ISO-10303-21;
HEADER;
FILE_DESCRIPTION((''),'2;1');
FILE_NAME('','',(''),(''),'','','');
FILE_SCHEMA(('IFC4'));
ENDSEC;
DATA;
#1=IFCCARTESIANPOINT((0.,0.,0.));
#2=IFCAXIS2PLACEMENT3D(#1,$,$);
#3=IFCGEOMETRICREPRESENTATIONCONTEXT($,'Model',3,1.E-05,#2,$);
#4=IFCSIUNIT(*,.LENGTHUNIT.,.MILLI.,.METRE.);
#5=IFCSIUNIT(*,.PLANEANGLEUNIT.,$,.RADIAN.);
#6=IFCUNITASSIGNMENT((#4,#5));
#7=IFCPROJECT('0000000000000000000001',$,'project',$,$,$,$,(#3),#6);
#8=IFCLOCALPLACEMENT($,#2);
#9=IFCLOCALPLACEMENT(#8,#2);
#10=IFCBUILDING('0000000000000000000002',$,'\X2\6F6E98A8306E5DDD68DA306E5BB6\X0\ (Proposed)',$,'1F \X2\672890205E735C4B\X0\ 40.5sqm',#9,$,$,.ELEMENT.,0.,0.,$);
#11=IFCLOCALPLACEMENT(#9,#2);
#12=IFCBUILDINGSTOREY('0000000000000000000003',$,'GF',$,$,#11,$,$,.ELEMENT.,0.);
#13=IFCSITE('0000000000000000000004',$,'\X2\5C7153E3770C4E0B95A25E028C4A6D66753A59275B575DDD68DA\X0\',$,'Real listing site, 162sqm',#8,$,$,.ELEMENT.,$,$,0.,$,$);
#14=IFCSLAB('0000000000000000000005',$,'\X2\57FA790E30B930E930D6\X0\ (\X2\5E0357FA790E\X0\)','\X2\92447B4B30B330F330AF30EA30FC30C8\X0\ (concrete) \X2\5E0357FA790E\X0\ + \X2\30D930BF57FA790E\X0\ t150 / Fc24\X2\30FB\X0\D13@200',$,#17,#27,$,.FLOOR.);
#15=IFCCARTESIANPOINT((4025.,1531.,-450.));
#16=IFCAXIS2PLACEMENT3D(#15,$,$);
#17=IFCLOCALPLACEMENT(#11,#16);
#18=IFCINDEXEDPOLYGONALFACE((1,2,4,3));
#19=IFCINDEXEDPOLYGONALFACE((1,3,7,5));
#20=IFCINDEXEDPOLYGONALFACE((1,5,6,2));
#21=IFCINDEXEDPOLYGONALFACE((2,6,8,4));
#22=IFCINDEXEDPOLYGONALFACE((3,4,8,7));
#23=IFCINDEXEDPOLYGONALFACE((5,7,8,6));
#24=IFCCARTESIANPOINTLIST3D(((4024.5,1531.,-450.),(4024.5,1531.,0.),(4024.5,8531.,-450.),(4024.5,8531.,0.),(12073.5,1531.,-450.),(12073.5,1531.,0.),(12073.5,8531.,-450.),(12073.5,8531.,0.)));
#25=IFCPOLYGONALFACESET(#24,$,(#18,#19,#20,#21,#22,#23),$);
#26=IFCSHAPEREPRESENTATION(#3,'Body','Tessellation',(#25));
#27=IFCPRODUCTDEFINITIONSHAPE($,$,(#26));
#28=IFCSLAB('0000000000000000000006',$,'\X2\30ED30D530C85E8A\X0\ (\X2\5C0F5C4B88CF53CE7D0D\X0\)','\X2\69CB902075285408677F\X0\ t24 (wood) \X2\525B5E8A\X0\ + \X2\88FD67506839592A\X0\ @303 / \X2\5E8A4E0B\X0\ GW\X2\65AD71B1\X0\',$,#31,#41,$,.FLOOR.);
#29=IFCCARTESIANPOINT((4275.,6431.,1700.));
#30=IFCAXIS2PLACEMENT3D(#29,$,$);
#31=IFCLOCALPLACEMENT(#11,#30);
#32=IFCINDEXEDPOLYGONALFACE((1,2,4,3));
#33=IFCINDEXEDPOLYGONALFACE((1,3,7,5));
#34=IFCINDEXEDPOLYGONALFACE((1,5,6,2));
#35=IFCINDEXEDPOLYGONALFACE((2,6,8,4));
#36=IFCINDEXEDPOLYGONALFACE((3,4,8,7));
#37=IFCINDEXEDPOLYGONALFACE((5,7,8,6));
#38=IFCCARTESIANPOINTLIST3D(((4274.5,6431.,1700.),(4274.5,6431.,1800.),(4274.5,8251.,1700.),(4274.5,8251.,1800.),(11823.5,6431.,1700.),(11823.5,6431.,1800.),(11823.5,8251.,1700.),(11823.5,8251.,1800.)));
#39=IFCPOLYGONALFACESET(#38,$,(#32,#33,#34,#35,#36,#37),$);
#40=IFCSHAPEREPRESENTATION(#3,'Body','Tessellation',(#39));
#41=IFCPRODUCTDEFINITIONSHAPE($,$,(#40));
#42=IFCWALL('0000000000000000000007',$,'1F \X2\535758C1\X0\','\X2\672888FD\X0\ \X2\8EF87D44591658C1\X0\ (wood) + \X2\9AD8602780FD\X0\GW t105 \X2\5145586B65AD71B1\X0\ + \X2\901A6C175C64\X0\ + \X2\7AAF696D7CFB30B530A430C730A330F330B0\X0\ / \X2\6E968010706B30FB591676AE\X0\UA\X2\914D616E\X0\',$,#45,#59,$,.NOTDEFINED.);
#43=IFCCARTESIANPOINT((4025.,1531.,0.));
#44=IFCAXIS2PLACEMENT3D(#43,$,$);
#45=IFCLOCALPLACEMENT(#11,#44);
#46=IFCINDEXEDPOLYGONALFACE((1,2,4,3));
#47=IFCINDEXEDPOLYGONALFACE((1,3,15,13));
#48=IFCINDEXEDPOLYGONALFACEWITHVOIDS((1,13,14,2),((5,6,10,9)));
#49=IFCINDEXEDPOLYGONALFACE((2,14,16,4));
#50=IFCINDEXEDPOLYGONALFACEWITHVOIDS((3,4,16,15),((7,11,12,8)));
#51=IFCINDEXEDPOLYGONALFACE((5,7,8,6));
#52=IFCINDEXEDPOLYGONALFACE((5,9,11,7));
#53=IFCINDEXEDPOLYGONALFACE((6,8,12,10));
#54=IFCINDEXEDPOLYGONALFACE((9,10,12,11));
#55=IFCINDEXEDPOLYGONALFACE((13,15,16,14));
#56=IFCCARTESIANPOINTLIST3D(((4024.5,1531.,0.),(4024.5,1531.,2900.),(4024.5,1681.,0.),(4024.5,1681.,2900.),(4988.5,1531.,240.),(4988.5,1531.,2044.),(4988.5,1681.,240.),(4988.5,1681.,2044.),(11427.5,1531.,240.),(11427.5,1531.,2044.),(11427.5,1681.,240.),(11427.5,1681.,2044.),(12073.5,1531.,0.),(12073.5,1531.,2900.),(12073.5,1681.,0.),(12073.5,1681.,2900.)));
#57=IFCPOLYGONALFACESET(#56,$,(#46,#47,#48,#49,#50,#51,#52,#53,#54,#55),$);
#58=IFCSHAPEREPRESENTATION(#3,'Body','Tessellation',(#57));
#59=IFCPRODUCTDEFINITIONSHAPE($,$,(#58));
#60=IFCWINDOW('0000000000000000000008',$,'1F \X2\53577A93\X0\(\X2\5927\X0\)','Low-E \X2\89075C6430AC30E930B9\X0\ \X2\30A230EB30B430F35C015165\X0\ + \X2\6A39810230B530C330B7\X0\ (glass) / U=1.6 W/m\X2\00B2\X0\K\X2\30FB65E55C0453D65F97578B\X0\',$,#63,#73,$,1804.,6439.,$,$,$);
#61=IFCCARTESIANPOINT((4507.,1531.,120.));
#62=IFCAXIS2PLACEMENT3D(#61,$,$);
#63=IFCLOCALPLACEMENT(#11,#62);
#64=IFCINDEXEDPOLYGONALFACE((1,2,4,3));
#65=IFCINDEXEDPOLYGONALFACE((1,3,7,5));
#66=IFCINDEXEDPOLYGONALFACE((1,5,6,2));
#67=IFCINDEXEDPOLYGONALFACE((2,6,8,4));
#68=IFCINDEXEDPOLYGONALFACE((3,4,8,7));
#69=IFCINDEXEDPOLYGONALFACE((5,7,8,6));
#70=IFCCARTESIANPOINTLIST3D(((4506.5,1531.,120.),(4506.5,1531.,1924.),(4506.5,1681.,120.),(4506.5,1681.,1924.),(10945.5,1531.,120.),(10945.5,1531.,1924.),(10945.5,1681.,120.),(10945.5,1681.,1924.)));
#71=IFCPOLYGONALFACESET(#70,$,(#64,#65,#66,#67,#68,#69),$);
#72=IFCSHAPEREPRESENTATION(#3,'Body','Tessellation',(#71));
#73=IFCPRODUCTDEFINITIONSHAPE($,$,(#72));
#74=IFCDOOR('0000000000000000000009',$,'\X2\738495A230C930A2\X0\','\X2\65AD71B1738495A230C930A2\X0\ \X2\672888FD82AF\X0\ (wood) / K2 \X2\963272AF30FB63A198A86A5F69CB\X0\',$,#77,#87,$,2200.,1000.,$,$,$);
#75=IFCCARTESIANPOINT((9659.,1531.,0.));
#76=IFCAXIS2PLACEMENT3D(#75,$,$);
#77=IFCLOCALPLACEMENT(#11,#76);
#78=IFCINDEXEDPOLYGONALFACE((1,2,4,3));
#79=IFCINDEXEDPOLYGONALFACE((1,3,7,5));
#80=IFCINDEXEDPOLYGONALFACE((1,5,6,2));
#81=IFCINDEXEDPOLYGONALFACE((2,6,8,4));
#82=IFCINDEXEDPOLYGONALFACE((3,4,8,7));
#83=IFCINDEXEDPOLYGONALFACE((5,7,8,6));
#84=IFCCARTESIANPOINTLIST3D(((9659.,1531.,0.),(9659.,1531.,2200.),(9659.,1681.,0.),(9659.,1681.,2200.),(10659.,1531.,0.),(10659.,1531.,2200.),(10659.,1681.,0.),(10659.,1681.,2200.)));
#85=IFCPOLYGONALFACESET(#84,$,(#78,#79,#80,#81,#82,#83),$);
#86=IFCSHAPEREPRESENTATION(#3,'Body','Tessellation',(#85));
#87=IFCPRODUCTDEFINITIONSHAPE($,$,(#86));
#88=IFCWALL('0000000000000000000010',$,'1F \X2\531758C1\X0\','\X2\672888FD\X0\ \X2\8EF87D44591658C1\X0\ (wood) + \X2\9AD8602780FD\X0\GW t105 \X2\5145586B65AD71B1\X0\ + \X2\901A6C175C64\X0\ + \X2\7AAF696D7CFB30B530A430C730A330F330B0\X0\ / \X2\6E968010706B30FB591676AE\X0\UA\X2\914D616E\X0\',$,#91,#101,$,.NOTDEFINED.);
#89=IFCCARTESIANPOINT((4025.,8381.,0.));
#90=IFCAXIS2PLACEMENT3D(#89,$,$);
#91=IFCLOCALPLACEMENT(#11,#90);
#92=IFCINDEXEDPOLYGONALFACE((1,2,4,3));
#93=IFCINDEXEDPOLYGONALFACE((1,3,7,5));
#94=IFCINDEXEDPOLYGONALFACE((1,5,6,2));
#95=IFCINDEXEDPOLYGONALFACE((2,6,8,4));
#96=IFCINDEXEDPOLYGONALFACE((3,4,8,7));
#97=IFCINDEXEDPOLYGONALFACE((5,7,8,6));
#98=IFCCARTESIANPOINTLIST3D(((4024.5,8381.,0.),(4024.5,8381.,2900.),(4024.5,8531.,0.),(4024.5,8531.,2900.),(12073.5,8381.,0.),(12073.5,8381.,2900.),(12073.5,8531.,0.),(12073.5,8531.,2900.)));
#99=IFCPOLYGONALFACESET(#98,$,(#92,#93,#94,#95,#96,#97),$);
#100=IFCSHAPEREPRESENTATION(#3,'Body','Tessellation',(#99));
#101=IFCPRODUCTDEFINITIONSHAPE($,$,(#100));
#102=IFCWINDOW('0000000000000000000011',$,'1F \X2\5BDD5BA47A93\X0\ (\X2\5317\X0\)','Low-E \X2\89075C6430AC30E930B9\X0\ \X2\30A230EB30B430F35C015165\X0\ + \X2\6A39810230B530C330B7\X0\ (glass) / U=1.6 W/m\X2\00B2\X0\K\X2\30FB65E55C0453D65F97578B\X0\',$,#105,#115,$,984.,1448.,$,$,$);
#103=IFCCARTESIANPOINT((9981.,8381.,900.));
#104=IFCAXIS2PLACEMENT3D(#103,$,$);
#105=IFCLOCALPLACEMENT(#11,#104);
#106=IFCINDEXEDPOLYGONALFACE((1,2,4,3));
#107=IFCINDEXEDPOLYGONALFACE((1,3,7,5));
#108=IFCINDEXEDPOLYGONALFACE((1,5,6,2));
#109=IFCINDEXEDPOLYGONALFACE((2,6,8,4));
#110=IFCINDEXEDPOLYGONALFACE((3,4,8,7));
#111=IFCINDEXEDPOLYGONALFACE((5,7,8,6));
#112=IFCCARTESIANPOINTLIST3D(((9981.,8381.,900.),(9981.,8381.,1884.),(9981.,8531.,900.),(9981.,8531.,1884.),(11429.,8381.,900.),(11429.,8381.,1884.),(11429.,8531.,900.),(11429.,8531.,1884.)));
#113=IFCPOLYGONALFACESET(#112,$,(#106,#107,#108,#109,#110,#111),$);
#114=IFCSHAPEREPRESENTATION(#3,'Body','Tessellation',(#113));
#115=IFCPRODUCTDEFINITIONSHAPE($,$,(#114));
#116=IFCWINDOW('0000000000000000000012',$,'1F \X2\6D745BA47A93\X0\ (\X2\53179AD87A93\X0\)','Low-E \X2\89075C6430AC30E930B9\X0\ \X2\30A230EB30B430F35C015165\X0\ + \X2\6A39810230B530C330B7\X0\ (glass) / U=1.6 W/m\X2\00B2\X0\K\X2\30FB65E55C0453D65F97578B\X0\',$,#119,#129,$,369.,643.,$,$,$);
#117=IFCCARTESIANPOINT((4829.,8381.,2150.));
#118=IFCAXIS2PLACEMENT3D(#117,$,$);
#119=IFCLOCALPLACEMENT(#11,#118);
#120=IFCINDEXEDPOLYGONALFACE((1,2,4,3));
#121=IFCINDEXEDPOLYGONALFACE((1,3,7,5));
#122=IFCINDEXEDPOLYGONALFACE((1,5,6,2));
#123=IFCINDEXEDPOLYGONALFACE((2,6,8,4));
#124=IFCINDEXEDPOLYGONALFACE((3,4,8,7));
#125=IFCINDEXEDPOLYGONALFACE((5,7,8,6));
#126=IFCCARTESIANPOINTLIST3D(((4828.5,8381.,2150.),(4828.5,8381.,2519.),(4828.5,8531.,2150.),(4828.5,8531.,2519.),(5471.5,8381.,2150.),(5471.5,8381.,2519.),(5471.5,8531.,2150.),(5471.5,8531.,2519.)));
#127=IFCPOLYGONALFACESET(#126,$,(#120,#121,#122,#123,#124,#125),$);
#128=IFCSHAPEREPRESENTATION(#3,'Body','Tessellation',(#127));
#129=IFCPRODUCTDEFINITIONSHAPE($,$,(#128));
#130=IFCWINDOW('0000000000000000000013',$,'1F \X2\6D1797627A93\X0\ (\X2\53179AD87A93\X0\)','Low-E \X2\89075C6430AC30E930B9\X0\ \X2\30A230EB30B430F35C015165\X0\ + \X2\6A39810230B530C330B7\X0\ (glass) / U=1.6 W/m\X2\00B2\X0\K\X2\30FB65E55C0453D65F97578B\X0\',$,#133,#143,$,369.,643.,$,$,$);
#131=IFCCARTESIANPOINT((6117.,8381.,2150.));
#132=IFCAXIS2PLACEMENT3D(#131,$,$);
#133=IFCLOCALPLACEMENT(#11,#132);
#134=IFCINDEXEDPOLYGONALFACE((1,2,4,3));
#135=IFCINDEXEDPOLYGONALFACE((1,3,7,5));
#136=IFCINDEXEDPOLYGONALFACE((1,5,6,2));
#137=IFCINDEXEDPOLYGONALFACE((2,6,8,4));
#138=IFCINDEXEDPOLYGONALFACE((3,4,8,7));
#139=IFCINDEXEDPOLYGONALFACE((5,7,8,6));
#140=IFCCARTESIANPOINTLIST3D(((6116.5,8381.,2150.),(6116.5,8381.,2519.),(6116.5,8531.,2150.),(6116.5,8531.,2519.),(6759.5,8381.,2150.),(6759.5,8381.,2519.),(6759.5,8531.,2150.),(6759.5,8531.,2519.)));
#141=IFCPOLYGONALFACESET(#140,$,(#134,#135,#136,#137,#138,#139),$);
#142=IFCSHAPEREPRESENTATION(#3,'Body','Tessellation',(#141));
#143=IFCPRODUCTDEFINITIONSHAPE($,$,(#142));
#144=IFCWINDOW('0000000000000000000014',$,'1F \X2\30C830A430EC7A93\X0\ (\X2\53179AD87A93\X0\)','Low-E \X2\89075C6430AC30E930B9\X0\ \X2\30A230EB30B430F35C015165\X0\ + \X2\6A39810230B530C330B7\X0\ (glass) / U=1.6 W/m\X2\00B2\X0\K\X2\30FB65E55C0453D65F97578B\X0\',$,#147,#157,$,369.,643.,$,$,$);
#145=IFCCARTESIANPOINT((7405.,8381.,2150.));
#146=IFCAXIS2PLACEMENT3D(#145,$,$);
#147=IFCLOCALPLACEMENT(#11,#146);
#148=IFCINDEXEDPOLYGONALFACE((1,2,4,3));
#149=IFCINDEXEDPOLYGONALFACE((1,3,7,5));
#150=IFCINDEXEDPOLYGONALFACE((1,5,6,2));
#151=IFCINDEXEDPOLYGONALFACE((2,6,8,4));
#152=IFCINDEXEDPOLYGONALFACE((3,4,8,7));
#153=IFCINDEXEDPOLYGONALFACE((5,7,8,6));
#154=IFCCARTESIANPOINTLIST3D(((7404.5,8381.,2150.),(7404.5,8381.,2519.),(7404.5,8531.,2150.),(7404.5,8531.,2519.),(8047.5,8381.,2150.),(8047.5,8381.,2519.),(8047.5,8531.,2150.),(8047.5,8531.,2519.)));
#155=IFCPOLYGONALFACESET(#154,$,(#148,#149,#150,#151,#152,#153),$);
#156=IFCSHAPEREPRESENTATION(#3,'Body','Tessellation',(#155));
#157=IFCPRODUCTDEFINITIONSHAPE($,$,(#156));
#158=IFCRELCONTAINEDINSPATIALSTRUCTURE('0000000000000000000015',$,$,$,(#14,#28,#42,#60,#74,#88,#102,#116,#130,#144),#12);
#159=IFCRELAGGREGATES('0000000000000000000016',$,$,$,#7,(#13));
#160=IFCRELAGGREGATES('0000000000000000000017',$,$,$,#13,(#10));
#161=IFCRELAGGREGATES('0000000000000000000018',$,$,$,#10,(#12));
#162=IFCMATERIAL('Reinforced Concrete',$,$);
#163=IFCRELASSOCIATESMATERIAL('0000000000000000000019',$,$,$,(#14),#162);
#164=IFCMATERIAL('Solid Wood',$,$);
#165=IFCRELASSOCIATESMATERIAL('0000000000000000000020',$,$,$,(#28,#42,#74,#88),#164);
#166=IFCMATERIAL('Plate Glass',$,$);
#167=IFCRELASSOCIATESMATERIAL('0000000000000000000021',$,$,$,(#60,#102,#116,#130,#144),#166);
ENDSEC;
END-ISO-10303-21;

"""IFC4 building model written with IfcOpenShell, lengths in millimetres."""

from ifc_helpers import new_model, si_unit, frame, frame_2d, origin, place, context, project, spatial, rectangle, extrude, material, element, fill, save


model = new_model("IFC4")

# Units and contexts
model_context = context("Model", 3, precision=1e-05, world=origin())
ifc_project = project(units=[si_unit("LENGTHUNIT", "METRE", prefix="MILLI"), si_unit("PLANEANGLEUNIT", "RADIAN")], contexts=[model_context])

# Site, building, storey
site_placement = place(None, origin())
site = spatial("IfcSite", under=ifc_project, at=site_placement, Name="山口県下関市豊浦町大字川棚", ObjectType="Real listing site, 162sqm", CompositionType="ELEMENT", RefElevation=0.0)
building_placement = place(site_placement, origin())
building = spatial("IfcBuilding", under=site, at=building_placement, Name="潮風の川棚の家 (Proposed)", ObjectType="1F 木造平屋 40.5sqm", CompositionType="ELEMENT", ElevationOfRefHeight=0.0, ElevationOfTerrain=0.0)
storey_placement = place(building_placement, origin())
storey = spatial("IfcBuildingStorey", under=building, at=storey_placement, Name="GF", CompositionType="ELEMENT", Elevation=0.0)

# Slabs
ifc_material_1 = material(Name="Reinforced Concrete")
slab_1_placement = place(storey_placement, frame((4025.0, 1531.0, -450.0)))
element("IfcSlab", 1, at=slab_1_placement, inside=storey, material=ifc_material_1, Name="基礎スラブ (布基礎)", Description="鉄筋コンクリート (concrete) 布基礎 + ベタ基礎 t150 / Fc24・D13@200", PredefinedType="FLOOR", context=model_context, shape_type="SweptSolid", body=[
    extrude(rectangle(XDim=8049.0, YDim=7000.0, at=frame_2d((4024.0, 3500.0))), frame((4025.0, 1531.0, -450.0)), (0.0, 0.0, 1.0), 450.0),
])
ifc_material_2 = material(Name="Solid Wood")
slab_2_placement = place(storey_placement, frame((4275.0, 6431.0, 1700.0)))
element("IfcSlab", 2, at=slab_2_placement, inside=storey, material=ifc_material_2, Name="ロフト床 (小屋裏収納)", Description="構造用合板 t24 (wood) 剛床 + 製材根太 @303 / 床下 GW断熱", PredefinedType="FLOOR", context=model_context, shape_type="SweptSolid", body=[
    extrude(rectangle(XDim=7549.0, YDim=1820.0, at=frame_2d((3774.0, 910.0))), frame((4275.0, 6431.0, 1700.0)), (0.0, 0.0, 1.0), 100.0),
])

# Wall, openings, window, door
wall_1_placement = place(storey_placement, frame((4025.0, 1531.0, 0.0)))
wall_1 = element("IfcWall", 3, at=wall_1_placement, inside=storey, material=ifc_material_2, Name="1F 南壁", Description="木製 軸組外壁 (wood) + 高性能GW t105 充填断熱 + 通気層 + 窯業系サイディング / 準耐火・外皮UA配慮", PredefinedType="NOTDEFINED", context=model_context, shape_type="SweptSolid", body=[
    extrude(rectangle(XDim=8049.0, YDim=150.0, at=frame_2d((4024.0, 75.0))), frame((4025.0, 1531.0, 0.0)), (0.0, 0.0, 1.0), 2900.0),
])
opening_1_placement = place(storey_placement, frame((4507.0, 1531.0, 120.0)))
opening_1 = element("IfcOpeningElement", 4, at=opening_1_placement, cuts=wall_1, PredefinedType="NOTDEFINED", context=model_context, shape_type="SweptSolid", body=[
    extrude(rectangle(XDim=6439.0, YDim=150.0, at=frame_2d((3219.0, 75.0))), frame((4507.0, 1531.0, 120.0)), (0.0, 0.0, 1.0), 1804.0),
])
opening_2_placement = place(storey_placement, frame((9659.0, 1531.0, 0.0)))
opening_2 = element("IfcOpeningElement", 5, at=opening_2_placement, cuts=wall_1, PredefinedType="NOTDEFINED", context=model_context, shape_type="SweptSolid", body=[
    extrude(rectangle(XDim=1000.0, YDim=150.0, at=frame_2d((500.0, 75.0))), frame((9659.0, 1531.0, 0.0)), (0.0, 0.0, 1.0), 2200.0),
])
ifc_material_3 = material(Name="Plate Glass")
window_1_placement = place(storey_placement, frame((4507.0, 1531.0, 120.0)))
window_1 = element("IfcWindow", 6, at=window_1_placement, inside=storey, material=ifc_material_3, Name="1F 南窓(大)", Description="Low-E 複層ガラス アルゴン封入 + 樹脂サッシ (glass) / U=1.6 W/m²K・日射取得型", OverallHeight=1804.0, OverallWidth=6439.0, context=model_context, shape_type="SweptSolid", body=[
    extrude(rectangle(XDim=6439.0, YDim=150.0, at=frame_2d((3219.0, 75.0))), frame((4507.0, 1531.0, 120.0)), (0.0, 0.0, 1.0), 1804.0),
])
fill(opening_1, window_1)
door_1_placement = place(storey_placement, frame((9659.0, 1531.0, 0.0)))
door_1 = element("IfcDoor", 7, at=door_1_placement, inside=storey, material=ifc_material_2, Name="玄関ドア", Description="断熱玄関ドア 木製芯 (wood) / K2 防犯・採風機構", OverallHeight=2200.0, OverallWidth=1000.0, context=model_context, shape_type="SweptSolid", body=[
    extrude(rectangle(XDim=1000.0, YDim=150.0, at=frame_2d((500.0, 75.0))), frame((9659.0, 1531.0, 0.0)), (0.0, 0.0, 1.0), 2200.0),
])
fill(opening_2, door_1)

# Wall, openings, windows
wall_2_placement = place(storey_placement, frame((4025.0, 8381.0, 0.0)))
wall_2 = element("IfcWall", 8, at=wall_2_placement, inside=storey, material=ifc_material_2, Name="1F 北壁", Description="木製 軸組外壁 (wood) + 高性能GW t105 充填断熱 + 通気層 + 窯業系サイディング / 準耐火・外皮UA配慮", PredefinedType="NOTDEFINED", context=model_context, shape_type="SweptSolid", body=[
    extrude(rectangle(XDim=8049.0, YDim=150.0, at=frame_2d((4024.0, 75.0))), frame((4025.0, 8381.0, 0.0)), (0.0, 0.0, 1.0), 2900.0),
])
opening_3_placement = place(storey_placement, frame((9981.0, 8381.0, 900.0)))
opening_3 = element("IfcOpeningElement", 9, at=opening_3_placement, cuts=wall_2, PredefinedType="NOTDEFINED", context=model_context, shape_type="SweptSolid", body=[
    extrude(rectangle(XDim=1448.0, YDim=150.0, at=frame_2d((724.0, 75.0))), frame((9981.0, 8381.0, 900.0)), (0.0, 0.0, 1.0), 984.0),
])
opening_4_placement = place(storey_placement, frame((4829.0, 8381.0, 2150.0)))
opening_4 = element("IfcOpeningElement", 10, at=opening_4_placement, cuts=wall_2, PredefinedType="NOTDEFINED", context=model_context, shape_type="SweptSolid", body=[
    extrude(rectangle(XDim=643.0, YDim=150.0, at=frame_2d((321.0, 75.0))), frame((4829.0, 8381.0, 2150.0)), (0.0, 0.0, 1.0), 369.0),
])
opening_5_placement = place(storey_placement, frame((6117.0, 8381.0, 2150.0)))
opening_5 = element("IfcOpeningElement", 11, at=opening_5_placement, cuts=wall_2, PredefinedType="NOTDEFINED", context=model_context, shape_type="SweptSolid", body=[
    extrude(rectangle(XDim=643.0, YDim=150.0, at=frame_2d((321.0, 75.0))), frame((6117.0, 8381.0, 2150.0)), (0.0, 0.0, 1.0), 369.0),
])
opening_6_placement = place(storey_placement, frame((7405.0, 8381.0, 2150.0)))
opening_6 = element("IfcOpeningElement", 12, at=opening_6_placement, cuts=wall_2, PredefinedType="NOTDEFINED", context=model_context, shape_type="SweptSolid", body=[
    extrude(rectangle(XDim=643.0, YDim=150.0, at=frame_2d((321.0, 75.0))), frame((7405.0, 8381.0, 2150.0)), (0.0, 0.0, 1.0), 369.0),
])
window_2_placement = place(storey_placement, frame((9981.0, 8381.0, 900.0)))
window_2 = element("IfcWindow", 13, at=window_2_placement, inside=storey, material=ifc_material_3, Name="1F 寝室窓 (北)", Description="Low-E 複層ガラス アルゴン封入 + 樹脂サッシ (glass) / U=1.6 W/m²K・日射取得型", OverallHeight=984.0, OverallWidth=1448.0, context=model_context, shape_type="SweptSolid", body=[
    extrude(rectangle(XDim=1448.0, YDim=150.0, at=frame_2d((724.0, 75.0))), frame((9981.0, 8381.0, 900.0)), (0.0, 0.0, 1.0), 984.0),
])
fill(opening_3, window_2)
window_3_placement = place(storey_placement, frame((4829.0, 8381.0, 2150.0)))
window_3 = element("IfcWindow", 14, at=window_3_placement, inside=storey, material=ifc_material_3, Name="1F 浴室窓 (北高窓)", Description="Low-E 複層ガラス アルゴン封入 + 樹脂サッシ (glass) / U=1.6 W/m²K・日射取得型", OverallHeight=369.0, OverallWidth=643.0, context=model_context, shape_type="SweptSolid", body=[
    extrude(rectangle(XDim=643.0, YDim=150.0, at=frame_2d((321.0, 75.0))), frame((4829.0, 8381.0, 2150.0)), (0.0, 0.0, 1.0), 369.0),
])
fill(opening_4, window_3)
window_4_placement = place(storey_placement, frame((6117.0, 8381.0, 2150.0)))
window_4 = element("IfcWindow", 15, at=window_4_placement, inside=storey, material=ifc_material_3, Name="1F 洗面窓 (北高窓)", Description="Low-E 複層ガラス アルゴン封入 + 樹脂サッシ (glass) / U=1.6 W/m²K・日射取得型", OverallHeight=369.0, OverallWidth=643.0, context=model_context, shape_type="SweptSolid", body=[
    extrude(rectangle(XDim=643.0, YDim=150.0, at=frame_2d((321.0, 75.0))), frame((6117.0, 8381.0, 2150.0)), (0.0, 0.0, 1.0), 369.0),
])
fill(opening_5, window_4)
window_5_placement = place(storey_placement, frame((7405.0, 8381.0, 2150.0)))
window_5 = element("IfcWindow", 16, at=window_5_placement, inside=storey, material=ifc_material_3, Name="1F トイレ窓 (北高窓)", Description="Low-E 複層ガラス アルゴン封入 + 樹脂サッシ (glass) / U=1.6 W/m²K・日射取得型", OverallHeight=369.0, OverallWidth=643.0, context=model_context, shape_type="SweptSolid", body=[
    extrude(rectangle(XDim=643.0, YDim=150.0, at=frame_2d((321.0, 75.0))), frame((7405.0, 8381.0, 2150.0)), (0.0, 0.0, 1.0), 369.0),
])
fill(opening_6, window_5)

save(model, "model.ifc")
